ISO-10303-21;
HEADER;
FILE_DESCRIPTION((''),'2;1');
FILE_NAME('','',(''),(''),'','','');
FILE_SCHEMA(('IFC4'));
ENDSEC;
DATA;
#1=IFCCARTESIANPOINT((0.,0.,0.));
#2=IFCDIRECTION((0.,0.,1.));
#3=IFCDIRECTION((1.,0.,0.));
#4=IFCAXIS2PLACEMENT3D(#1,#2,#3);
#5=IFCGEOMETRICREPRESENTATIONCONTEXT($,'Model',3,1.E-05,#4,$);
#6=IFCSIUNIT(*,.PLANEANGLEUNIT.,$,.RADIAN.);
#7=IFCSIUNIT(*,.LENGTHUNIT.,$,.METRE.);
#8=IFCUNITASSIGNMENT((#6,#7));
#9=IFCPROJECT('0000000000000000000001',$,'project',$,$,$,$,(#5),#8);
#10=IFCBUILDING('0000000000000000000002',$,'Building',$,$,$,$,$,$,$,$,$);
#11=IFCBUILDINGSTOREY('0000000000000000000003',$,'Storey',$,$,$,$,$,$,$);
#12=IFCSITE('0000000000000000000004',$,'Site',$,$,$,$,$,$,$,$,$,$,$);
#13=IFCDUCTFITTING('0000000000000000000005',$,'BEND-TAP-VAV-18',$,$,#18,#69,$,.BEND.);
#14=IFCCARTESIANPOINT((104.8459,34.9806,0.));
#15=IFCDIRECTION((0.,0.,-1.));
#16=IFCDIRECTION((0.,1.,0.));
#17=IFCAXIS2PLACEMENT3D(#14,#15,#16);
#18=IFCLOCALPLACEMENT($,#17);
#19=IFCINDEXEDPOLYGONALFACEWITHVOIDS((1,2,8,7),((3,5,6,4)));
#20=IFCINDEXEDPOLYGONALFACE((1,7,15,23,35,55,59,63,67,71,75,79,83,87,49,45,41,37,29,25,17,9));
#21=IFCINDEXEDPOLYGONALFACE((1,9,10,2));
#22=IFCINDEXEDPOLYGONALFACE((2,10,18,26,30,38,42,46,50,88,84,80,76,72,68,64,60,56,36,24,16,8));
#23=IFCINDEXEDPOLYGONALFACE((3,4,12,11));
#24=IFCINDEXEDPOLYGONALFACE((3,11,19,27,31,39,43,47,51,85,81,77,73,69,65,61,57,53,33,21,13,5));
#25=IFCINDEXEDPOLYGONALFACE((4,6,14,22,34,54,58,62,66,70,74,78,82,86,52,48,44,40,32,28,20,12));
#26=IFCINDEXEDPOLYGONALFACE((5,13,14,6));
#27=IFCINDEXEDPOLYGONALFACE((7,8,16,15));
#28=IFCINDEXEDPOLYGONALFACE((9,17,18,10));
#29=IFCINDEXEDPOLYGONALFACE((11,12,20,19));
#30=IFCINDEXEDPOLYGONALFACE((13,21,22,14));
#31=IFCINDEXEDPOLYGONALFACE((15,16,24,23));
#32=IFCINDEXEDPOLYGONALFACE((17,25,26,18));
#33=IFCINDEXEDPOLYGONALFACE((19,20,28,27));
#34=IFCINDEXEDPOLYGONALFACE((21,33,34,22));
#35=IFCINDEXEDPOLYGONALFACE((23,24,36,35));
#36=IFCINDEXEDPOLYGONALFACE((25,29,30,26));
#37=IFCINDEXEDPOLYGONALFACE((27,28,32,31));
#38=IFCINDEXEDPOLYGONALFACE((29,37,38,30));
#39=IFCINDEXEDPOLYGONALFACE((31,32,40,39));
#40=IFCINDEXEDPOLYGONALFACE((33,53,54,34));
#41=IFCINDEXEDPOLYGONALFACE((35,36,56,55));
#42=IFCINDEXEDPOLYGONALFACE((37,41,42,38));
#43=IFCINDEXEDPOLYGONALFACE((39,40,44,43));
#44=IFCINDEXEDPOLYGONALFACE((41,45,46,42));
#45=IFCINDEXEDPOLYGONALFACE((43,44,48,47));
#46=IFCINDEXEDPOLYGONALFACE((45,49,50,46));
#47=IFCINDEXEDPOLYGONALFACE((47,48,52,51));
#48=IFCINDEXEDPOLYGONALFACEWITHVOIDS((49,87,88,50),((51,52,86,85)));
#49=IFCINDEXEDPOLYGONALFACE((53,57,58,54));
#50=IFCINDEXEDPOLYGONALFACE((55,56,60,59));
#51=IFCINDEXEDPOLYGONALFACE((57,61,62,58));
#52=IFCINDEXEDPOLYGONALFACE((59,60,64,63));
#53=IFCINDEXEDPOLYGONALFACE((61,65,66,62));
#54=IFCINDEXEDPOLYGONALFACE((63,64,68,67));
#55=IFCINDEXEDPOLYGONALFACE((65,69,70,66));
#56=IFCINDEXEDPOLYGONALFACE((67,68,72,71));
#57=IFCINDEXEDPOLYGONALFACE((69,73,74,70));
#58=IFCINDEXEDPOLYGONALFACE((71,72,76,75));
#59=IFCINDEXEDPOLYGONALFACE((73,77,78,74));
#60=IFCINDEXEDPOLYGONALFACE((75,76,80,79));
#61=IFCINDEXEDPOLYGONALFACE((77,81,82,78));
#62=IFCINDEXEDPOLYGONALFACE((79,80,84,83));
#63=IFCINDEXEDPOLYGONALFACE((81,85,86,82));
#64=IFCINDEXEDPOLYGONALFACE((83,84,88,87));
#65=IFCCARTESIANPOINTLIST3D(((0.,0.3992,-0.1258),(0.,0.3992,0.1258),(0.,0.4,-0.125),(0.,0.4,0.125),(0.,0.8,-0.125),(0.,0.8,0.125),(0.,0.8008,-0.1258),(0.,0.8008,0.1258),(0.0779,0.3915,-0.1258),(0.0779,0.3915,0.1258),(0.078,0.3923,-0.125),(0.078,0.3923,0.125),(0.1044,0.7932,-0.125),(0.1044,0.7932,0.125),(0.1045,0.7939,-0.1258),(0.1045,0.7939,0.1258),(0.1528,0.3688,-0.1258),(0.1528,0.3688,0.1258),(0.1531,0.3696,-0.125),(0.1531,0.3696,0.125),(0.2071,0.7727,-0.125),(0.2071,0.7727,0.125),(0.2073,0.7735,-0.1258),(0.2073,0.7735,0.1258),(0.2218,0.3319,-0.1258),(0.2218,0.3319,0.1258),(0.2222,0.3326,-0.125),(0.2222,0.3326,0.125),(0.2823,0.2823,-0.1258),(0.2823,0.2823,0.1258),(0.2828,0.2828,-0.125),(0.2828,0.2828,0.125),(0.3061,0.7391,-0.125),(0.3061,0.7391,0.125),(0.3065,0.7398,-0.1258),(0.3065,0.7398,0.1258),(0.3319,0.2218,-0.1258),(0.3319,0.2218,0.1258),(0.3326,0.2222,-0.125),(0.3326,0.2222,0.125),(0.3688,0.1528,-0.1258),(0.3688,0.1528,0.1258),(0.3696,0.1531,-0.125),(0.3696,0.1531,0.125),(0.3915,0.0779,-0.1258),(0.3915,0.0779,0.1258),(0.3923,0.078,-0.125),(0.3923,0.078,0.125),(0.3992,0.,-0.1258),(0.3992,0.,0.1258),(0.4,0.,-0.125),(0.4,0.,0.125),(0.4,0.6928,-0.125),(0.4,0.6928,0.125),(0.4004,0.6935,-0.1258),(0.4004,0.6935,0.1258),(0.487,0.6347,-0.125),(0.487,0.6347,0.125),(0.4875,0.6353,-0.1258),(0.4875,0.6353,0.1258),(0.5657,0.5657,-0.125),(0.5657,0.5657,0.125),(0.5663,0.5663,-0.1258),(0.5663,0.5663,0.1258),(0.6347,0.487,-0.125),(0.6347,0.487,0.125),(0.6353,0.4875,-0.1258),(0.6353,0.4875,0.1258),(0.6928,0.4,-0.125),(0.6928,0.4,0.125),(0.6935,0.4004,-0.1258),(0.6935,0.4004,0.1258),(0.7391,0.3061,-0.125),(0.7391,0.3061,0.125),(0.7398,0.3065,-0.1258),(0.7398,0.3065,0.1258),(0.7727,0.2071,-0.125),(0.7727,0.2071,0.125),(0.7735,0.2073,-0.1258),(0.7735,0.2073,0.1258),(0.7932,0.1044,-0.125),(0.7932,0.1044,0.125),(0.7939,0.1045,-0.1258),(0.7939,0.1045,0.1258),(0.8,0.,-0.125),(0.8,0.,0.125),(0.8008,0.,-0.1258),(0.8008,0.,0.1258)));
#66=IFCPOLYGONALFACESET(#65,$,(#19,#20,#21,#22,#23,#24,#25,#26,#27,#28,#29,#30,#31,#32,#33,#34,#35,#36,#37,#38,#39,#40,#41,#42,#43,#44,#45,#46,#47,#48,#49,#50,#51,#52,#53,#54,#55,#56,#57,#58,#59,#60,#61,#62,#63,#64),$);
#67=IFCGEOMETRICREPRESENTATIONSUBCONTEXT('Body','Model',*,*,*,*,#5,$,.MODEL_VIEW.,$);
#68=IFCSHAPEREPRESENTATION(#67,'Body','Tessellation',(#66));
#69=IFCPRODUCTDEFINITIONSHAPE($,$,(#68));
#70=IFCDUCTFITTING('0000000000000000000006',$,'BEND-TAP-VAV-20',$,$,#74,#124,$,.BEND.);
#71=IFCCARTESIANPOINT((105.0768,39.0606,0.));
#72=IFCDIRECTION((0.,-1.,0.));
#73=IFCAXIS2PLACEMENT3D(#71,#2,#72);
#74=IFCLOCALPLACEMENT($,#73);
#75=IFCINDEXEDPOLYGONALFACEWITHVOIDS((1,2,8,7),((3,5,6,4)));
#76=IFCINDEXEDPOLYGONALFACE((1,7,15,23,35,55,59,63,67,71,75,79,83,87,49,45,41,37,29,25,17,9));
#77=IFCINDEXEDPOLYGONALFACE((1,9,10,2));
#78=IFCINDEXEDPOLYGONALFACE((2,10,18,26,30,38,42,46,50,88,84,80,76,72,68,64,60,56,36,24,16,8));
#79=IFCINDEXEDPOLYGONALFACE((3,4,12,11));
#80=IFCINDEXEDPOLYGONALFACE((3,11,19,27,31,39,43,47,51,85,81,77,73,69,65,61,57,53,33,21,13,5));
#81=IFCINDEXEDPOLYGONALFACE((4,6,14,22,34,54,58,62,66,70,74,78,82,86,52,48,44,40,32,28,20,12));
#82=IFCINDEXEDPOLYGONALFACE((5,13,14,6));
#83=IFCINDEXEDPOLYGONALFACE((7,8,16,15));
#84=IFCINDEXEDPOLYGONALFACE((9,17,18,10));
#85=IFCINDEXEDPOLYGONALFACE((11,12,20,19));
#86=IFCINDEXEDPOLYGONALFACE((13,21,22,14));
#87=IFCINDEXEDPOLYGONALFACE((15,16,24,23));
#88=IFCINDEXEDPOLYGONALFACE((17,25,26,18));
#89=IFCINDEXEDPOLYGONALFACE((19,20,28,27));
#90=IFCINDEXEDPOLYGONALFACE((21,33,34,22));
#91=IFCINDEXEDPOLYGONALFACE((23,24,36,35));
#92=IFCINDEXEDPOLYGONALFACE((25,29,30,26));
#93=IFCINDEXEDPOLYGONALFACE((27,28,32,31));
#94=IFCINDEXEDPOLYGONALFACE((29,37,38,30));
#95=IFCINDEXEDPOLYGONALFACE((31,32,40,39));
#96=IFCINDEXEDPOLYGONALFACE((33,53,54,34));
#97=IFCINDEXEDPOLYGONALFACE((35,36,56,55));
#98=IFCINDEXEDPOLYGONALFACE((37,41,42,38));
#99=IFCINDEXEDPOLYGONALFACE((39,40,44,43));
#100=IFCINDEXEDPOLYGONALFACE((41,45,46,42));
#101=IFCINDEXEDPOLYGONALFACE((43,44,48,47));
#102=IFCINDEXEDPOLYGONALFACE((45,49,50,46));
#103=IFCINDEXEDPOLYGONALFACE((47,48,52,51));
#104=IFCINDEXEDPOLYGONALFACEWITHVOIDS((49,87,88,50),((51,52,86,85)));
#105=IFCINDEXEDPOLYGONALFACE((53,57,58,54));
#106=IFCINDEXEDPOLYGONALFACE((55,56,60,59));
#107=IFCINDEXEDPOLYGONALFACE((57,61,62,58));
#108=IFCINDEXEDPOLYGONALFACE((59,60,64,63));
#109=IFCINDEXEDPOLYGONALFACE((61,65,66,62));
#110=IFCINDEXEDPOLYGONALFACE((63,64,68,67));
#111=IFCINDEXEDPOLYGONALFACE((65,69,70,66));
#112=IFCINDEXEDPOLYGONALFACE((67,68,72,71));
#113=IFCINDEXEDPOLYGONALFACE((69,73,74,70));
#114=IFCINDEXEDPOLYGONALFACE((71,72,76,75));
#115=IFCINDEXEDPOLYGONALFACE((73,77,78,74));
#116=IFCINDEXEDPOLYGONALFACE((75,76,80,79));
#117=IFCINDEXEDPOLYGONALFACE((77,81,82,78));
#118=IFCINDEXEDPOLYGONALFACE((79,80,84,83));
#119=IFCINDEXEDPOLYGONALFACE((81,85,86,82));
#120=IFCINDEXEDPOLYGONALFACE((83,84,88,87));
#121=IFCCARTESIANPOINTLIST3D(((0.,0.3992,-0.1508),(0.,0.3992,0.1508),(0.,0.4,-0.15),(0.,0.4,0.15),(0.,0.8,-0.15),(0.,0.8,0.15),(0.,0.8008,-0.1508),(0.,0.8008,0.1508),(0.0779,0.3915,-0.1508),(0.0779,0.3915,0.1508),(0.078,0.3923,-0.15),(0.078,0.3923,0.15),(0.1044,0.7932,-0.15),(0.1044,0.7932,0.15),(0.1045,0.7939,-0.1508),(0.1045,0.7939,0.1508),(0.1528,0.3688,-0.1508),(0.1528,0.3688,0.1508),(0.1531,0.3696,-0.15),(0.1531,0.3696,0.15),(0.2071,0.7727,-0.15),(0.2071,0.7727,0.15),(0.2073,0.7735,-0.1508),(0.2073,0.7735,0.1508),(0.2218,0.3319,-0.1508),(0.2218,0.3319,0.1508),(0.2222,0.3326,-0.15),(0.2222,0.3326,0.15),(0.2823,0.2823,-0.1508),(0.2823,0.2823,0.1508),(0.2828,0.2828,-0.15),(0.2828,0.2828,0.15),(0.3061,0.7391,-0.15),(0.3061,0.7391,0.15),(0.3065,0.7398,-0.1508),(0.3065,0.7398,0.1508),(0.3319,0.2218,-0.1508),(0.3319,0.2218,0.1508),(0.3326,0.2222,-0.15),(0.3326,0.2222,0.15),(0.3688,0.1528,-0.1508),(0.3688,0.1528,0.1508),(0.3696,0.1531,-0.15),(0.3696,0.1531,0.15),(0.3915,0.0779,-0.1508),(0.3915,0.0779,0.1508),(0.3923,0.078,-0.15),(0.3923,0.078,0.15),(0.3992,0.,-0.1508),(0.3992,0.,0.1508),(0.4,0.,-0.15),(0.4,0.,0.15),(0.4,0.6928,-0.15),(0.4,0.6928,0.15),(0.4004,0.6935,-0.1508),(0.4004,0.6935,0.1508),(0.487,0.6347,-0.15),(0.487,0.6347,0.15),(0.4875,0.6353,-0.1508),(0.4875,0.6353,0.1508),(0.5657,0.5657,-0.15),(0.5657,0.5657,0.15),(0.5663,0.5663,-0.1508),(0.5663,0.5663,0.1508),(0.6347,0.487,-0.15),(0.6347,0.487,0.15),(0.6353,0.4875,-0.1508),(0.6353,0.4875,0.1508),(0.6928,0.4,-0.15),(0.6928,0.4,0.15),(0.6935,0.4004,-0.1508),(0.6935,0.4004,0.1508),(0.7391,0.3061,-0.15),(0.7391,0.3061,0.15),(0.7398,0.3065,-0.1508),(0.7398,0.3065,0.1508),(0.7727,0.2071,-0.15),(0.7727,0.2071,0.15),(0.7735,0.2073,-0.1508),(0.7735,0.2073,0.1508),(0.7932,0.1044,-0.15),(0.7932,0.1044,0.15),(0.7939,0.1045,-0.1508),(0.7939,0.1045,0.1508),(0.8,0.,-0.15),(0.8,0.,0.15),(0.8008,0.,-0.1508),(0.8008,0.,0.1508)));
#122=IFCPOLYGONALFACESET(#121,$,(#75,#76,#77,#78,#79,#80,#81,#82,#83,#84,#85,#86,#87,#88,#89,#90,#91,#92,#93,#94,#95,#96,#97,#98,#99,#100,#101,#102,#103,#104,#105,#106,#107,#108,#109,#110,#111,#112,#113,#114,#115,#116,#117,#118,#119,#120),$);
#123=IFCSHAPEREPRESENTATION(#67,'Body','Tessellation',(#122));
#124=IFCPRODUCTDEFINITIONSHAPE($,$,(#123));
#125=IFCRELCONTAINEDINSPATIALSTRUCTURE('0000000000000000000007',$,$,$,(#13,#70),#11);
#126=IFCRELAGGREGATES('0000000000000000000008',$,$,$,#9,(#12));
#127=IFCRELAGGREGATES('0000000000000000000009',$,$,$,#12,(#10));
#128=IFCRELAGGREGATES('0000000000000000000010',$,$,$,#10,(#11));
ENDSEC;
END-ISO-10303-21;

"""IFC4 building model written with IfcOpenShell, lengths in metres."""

from ifc_helpers import new_model, entity, si_unit, frame, origin_with_axes, place, context, subcontext, project, spatial, element, save


model = new_model("IFC4")

# Units and contexts
model_context = context("Model", 3, precision=1e-05, world=origin_with_axes())
body_context = subcontext(model_context, "Body", "Model", "MODEL_VIEW")
ifc_project = project(units=[si_unit("PLANEANGLEUNIT", "RADIAN"), si_unit("LENGTHUNIT", "METRE")], contexts=[model_context])

# Site, building, storey
site = spatial("IfcSite", under=ifc_project, Name="Site")
building = spatial("IfcBuilding", under=site, Name="Building")
storey = spatial("IfcBuildingStorey", under=building, Name="Storey")

# Duct fittings
duct_fitting_1_placement = place(None, frame((104.8459, 34.9806, 0.0), z_axis=(0.0, 0.0, -1.0), x_axis=(0.0, 1.0, 0.0)))
cartesian_point_1 = entity("IfcCartesianPoint", [0.0, 0.0, 0.0])
element("IfcDuctFitting", 1, at=duct_fitting_1_placement, inside=storey, Name="BEND-TAP-VAV-18", PredefinedType="BEND", context=body_context, shape_type="SweptSolid", body=[
    entity("IfcRevolvedAreaSolid", entity("IfcRectangleHollowProfileDef", "AREA", None, entity("IfcAxis2Placement2D", entity("IfcCartesianPoint", [0.6, 0.0])), 0.4016, 0.2516, 0.0008), entity("IfcAxis2Placement3D", cartesian_point_1, entity("IfcDirection", [0.0, -1.0, 0.0]), entity("IfcDirection", [1.0, 0.0, 0.0])), entity("IfcAxis1Placement", cartesian_point_1, entity("IfcDirection", [0.0, 1.0, 0.0])), 1.570796),
])
duct_fitting_2_placement = place(None, frame((105.0768, 39.0606, 0.0), z_axis=(0.0, 0.0, 1.0), x_axis=(0.0, -1.0, 0.0)))
cartesian_point_2 = entity("IfcCartesianPoint", [0.0, 0.0, 0.0])
element("IfcDuctFitting", 2, at=duct_fitting_2_placement, inside=storey, Name="BEND-TAP-VAV-20", PredefinedType="BEND", context=body_context, shape_type="SweptSolid", body=[
    entity("IfcRevolvedAreaSolid", entity("IfcRectangleHollowProfileDef", "AREA", None, entity("IfcAxis2Placement2D", entity("IfcCartesianPoint", [0.6, 0.0])), 0.4016, 0.3016, 0.0008), entity("IfcAxis2Placement3D", cartesian_point_2, entity("IfcDirection", [0.0, -1.0, 0.0]), entity("IfcDirection", [1.0, 0.0, 0.0])), entity("IfcAxis1Placement", cartesian_point_2, entity("IfcDirection", [0.0, 1.0, 0.0])), 1.570796),
])

save(model, "model.ifc")
